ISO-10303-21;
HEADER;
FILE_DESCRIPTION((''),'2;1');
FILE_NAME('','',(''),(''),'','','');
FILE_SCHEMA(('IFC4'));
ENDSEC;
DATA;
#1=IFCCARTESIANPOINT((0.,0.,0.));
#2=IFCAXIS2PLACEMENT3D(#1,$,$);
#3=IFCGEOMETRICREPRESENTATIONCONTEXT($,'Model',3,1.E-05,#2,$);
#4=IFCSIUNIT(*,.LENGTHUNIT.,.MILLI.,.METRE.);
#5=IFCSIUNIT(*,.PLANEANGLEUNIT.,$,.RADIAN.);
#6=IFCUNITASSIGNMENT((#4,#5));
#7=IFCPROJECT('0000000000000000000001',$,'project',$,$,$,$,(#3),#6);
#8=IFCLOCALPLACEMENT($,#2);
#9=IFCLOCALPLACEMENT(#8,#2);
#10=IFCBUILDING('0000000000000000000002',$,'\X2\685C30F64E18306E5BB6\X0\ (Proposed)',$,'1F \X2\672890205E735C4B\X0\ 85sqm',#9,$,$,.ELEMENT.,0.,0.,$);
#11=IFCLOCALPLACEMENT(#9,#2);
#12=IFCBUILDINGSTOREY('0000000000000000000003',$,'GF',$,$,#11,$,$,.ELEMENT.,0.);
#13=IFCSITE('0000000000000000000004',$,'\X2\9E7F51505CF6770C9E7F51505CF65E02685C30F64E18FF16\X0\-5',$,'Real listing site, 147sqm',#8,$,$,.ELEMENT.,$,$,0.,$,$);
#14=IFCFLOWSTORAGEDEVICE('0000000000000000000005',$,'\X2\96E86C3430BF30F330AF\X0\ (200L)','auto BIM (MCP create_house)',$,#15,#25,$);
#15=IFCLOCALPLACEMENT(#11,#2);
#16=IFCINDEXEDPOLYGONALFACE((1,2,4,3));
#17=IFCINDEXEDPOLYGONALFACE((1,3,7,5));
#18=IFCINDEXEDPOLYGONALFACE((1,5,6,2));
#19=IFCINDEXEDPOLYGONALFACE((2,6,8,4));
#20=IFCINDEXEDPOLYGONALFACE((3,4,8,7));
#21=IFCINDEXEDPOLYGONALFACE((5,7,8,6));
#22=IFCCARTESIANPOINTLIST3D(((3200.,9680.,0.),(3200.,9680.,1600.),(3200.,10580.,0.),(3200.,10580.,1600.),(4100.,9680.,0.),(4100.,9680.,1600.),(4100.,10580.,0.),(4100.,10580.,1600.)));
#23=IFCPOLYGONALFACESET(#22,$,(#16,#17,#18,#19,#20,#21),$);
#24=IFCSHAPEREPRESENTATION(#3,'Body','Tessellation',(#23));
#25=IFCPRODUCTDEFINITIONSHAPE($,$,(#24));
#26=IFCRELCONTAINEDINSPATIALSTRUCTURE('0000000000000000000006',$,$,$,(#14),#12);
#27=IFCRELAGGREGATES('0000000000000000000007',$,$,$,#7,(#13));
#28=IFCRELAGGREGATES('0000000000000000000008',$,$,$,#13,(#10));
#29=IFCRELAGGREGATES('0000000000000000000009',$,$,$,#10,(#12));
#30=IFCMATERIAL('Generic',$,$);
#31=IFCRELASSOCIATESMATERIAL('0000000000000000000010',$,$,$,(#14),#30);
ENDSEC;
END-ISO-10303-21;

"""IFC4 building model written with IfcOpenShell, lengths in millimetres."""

from ifc_helpers import new_model, si_unit, frame, frame_2d, origin, place, context, project, spatial, rectangle, extrude, material, element, save


model = new_model("IFC4")

# Units and contexts
model_context = context("Model", 3, precision=1e-05, world=origin())
ifc_project = project(units=[si_unit("LENGTHUNIT", "METRE", prefix="MILLI"), si_unit("PLANEANGLEUNIT", "RADIAN")], contexts=[model_context])

# Site, building, storey
site_placement = place(None, origin())
site = spatial("IfcSite", under=ifc_project, at=site_placement, Name="鹿児島県鹿児島市桜ヶ丘６-5", ObjectType="Real listing site, 147sqm", CompositionType="ELEMENT", RefElevation=0.0)
building_placement = place(site_placement, origin())
building = spatial("IfcBuilding", under=site, at=building_placement, Name="桜ヶ丘の家 (Proposed)", ObjectType="1F 木造平屋 85sqm", CompositionType="ELEMENT", ElevationOfRefHeight=0.0, ElevationOfTerrain=0.0)
storey_placement = place(building_placement, origin())
storey = spatial("IfcBuildingStorey", under=building, at=storey_placement, Name="GF", CompositionType="ELEMENT", Elevation=0.0)

# Shared definitions
ifc_material_1 = material(Name="Generic")

# Flow storage device
flow_storage_device_placement = place(storey_placement, frame((1600.0, 4840.0, 0.0)))
element("IfcFlowStorageDevice", 1, at=flow_storage_device_placement, inside=storey, material=ifc_material_1, Name="雨水タンク (200L)", Description="auto BIM (MCP create_house)", context=model_context, shape_type="SweptSolid", body=[
    extrude(rectangle(XDim=900.0, YDim=900.0, at=frame_2d((450.0, 450.0))), frame((1600.0, 4840.0, 0.0)), (0.0, 0.0, 1.0), 1600.0),
])

save(model, "model.ifc")
